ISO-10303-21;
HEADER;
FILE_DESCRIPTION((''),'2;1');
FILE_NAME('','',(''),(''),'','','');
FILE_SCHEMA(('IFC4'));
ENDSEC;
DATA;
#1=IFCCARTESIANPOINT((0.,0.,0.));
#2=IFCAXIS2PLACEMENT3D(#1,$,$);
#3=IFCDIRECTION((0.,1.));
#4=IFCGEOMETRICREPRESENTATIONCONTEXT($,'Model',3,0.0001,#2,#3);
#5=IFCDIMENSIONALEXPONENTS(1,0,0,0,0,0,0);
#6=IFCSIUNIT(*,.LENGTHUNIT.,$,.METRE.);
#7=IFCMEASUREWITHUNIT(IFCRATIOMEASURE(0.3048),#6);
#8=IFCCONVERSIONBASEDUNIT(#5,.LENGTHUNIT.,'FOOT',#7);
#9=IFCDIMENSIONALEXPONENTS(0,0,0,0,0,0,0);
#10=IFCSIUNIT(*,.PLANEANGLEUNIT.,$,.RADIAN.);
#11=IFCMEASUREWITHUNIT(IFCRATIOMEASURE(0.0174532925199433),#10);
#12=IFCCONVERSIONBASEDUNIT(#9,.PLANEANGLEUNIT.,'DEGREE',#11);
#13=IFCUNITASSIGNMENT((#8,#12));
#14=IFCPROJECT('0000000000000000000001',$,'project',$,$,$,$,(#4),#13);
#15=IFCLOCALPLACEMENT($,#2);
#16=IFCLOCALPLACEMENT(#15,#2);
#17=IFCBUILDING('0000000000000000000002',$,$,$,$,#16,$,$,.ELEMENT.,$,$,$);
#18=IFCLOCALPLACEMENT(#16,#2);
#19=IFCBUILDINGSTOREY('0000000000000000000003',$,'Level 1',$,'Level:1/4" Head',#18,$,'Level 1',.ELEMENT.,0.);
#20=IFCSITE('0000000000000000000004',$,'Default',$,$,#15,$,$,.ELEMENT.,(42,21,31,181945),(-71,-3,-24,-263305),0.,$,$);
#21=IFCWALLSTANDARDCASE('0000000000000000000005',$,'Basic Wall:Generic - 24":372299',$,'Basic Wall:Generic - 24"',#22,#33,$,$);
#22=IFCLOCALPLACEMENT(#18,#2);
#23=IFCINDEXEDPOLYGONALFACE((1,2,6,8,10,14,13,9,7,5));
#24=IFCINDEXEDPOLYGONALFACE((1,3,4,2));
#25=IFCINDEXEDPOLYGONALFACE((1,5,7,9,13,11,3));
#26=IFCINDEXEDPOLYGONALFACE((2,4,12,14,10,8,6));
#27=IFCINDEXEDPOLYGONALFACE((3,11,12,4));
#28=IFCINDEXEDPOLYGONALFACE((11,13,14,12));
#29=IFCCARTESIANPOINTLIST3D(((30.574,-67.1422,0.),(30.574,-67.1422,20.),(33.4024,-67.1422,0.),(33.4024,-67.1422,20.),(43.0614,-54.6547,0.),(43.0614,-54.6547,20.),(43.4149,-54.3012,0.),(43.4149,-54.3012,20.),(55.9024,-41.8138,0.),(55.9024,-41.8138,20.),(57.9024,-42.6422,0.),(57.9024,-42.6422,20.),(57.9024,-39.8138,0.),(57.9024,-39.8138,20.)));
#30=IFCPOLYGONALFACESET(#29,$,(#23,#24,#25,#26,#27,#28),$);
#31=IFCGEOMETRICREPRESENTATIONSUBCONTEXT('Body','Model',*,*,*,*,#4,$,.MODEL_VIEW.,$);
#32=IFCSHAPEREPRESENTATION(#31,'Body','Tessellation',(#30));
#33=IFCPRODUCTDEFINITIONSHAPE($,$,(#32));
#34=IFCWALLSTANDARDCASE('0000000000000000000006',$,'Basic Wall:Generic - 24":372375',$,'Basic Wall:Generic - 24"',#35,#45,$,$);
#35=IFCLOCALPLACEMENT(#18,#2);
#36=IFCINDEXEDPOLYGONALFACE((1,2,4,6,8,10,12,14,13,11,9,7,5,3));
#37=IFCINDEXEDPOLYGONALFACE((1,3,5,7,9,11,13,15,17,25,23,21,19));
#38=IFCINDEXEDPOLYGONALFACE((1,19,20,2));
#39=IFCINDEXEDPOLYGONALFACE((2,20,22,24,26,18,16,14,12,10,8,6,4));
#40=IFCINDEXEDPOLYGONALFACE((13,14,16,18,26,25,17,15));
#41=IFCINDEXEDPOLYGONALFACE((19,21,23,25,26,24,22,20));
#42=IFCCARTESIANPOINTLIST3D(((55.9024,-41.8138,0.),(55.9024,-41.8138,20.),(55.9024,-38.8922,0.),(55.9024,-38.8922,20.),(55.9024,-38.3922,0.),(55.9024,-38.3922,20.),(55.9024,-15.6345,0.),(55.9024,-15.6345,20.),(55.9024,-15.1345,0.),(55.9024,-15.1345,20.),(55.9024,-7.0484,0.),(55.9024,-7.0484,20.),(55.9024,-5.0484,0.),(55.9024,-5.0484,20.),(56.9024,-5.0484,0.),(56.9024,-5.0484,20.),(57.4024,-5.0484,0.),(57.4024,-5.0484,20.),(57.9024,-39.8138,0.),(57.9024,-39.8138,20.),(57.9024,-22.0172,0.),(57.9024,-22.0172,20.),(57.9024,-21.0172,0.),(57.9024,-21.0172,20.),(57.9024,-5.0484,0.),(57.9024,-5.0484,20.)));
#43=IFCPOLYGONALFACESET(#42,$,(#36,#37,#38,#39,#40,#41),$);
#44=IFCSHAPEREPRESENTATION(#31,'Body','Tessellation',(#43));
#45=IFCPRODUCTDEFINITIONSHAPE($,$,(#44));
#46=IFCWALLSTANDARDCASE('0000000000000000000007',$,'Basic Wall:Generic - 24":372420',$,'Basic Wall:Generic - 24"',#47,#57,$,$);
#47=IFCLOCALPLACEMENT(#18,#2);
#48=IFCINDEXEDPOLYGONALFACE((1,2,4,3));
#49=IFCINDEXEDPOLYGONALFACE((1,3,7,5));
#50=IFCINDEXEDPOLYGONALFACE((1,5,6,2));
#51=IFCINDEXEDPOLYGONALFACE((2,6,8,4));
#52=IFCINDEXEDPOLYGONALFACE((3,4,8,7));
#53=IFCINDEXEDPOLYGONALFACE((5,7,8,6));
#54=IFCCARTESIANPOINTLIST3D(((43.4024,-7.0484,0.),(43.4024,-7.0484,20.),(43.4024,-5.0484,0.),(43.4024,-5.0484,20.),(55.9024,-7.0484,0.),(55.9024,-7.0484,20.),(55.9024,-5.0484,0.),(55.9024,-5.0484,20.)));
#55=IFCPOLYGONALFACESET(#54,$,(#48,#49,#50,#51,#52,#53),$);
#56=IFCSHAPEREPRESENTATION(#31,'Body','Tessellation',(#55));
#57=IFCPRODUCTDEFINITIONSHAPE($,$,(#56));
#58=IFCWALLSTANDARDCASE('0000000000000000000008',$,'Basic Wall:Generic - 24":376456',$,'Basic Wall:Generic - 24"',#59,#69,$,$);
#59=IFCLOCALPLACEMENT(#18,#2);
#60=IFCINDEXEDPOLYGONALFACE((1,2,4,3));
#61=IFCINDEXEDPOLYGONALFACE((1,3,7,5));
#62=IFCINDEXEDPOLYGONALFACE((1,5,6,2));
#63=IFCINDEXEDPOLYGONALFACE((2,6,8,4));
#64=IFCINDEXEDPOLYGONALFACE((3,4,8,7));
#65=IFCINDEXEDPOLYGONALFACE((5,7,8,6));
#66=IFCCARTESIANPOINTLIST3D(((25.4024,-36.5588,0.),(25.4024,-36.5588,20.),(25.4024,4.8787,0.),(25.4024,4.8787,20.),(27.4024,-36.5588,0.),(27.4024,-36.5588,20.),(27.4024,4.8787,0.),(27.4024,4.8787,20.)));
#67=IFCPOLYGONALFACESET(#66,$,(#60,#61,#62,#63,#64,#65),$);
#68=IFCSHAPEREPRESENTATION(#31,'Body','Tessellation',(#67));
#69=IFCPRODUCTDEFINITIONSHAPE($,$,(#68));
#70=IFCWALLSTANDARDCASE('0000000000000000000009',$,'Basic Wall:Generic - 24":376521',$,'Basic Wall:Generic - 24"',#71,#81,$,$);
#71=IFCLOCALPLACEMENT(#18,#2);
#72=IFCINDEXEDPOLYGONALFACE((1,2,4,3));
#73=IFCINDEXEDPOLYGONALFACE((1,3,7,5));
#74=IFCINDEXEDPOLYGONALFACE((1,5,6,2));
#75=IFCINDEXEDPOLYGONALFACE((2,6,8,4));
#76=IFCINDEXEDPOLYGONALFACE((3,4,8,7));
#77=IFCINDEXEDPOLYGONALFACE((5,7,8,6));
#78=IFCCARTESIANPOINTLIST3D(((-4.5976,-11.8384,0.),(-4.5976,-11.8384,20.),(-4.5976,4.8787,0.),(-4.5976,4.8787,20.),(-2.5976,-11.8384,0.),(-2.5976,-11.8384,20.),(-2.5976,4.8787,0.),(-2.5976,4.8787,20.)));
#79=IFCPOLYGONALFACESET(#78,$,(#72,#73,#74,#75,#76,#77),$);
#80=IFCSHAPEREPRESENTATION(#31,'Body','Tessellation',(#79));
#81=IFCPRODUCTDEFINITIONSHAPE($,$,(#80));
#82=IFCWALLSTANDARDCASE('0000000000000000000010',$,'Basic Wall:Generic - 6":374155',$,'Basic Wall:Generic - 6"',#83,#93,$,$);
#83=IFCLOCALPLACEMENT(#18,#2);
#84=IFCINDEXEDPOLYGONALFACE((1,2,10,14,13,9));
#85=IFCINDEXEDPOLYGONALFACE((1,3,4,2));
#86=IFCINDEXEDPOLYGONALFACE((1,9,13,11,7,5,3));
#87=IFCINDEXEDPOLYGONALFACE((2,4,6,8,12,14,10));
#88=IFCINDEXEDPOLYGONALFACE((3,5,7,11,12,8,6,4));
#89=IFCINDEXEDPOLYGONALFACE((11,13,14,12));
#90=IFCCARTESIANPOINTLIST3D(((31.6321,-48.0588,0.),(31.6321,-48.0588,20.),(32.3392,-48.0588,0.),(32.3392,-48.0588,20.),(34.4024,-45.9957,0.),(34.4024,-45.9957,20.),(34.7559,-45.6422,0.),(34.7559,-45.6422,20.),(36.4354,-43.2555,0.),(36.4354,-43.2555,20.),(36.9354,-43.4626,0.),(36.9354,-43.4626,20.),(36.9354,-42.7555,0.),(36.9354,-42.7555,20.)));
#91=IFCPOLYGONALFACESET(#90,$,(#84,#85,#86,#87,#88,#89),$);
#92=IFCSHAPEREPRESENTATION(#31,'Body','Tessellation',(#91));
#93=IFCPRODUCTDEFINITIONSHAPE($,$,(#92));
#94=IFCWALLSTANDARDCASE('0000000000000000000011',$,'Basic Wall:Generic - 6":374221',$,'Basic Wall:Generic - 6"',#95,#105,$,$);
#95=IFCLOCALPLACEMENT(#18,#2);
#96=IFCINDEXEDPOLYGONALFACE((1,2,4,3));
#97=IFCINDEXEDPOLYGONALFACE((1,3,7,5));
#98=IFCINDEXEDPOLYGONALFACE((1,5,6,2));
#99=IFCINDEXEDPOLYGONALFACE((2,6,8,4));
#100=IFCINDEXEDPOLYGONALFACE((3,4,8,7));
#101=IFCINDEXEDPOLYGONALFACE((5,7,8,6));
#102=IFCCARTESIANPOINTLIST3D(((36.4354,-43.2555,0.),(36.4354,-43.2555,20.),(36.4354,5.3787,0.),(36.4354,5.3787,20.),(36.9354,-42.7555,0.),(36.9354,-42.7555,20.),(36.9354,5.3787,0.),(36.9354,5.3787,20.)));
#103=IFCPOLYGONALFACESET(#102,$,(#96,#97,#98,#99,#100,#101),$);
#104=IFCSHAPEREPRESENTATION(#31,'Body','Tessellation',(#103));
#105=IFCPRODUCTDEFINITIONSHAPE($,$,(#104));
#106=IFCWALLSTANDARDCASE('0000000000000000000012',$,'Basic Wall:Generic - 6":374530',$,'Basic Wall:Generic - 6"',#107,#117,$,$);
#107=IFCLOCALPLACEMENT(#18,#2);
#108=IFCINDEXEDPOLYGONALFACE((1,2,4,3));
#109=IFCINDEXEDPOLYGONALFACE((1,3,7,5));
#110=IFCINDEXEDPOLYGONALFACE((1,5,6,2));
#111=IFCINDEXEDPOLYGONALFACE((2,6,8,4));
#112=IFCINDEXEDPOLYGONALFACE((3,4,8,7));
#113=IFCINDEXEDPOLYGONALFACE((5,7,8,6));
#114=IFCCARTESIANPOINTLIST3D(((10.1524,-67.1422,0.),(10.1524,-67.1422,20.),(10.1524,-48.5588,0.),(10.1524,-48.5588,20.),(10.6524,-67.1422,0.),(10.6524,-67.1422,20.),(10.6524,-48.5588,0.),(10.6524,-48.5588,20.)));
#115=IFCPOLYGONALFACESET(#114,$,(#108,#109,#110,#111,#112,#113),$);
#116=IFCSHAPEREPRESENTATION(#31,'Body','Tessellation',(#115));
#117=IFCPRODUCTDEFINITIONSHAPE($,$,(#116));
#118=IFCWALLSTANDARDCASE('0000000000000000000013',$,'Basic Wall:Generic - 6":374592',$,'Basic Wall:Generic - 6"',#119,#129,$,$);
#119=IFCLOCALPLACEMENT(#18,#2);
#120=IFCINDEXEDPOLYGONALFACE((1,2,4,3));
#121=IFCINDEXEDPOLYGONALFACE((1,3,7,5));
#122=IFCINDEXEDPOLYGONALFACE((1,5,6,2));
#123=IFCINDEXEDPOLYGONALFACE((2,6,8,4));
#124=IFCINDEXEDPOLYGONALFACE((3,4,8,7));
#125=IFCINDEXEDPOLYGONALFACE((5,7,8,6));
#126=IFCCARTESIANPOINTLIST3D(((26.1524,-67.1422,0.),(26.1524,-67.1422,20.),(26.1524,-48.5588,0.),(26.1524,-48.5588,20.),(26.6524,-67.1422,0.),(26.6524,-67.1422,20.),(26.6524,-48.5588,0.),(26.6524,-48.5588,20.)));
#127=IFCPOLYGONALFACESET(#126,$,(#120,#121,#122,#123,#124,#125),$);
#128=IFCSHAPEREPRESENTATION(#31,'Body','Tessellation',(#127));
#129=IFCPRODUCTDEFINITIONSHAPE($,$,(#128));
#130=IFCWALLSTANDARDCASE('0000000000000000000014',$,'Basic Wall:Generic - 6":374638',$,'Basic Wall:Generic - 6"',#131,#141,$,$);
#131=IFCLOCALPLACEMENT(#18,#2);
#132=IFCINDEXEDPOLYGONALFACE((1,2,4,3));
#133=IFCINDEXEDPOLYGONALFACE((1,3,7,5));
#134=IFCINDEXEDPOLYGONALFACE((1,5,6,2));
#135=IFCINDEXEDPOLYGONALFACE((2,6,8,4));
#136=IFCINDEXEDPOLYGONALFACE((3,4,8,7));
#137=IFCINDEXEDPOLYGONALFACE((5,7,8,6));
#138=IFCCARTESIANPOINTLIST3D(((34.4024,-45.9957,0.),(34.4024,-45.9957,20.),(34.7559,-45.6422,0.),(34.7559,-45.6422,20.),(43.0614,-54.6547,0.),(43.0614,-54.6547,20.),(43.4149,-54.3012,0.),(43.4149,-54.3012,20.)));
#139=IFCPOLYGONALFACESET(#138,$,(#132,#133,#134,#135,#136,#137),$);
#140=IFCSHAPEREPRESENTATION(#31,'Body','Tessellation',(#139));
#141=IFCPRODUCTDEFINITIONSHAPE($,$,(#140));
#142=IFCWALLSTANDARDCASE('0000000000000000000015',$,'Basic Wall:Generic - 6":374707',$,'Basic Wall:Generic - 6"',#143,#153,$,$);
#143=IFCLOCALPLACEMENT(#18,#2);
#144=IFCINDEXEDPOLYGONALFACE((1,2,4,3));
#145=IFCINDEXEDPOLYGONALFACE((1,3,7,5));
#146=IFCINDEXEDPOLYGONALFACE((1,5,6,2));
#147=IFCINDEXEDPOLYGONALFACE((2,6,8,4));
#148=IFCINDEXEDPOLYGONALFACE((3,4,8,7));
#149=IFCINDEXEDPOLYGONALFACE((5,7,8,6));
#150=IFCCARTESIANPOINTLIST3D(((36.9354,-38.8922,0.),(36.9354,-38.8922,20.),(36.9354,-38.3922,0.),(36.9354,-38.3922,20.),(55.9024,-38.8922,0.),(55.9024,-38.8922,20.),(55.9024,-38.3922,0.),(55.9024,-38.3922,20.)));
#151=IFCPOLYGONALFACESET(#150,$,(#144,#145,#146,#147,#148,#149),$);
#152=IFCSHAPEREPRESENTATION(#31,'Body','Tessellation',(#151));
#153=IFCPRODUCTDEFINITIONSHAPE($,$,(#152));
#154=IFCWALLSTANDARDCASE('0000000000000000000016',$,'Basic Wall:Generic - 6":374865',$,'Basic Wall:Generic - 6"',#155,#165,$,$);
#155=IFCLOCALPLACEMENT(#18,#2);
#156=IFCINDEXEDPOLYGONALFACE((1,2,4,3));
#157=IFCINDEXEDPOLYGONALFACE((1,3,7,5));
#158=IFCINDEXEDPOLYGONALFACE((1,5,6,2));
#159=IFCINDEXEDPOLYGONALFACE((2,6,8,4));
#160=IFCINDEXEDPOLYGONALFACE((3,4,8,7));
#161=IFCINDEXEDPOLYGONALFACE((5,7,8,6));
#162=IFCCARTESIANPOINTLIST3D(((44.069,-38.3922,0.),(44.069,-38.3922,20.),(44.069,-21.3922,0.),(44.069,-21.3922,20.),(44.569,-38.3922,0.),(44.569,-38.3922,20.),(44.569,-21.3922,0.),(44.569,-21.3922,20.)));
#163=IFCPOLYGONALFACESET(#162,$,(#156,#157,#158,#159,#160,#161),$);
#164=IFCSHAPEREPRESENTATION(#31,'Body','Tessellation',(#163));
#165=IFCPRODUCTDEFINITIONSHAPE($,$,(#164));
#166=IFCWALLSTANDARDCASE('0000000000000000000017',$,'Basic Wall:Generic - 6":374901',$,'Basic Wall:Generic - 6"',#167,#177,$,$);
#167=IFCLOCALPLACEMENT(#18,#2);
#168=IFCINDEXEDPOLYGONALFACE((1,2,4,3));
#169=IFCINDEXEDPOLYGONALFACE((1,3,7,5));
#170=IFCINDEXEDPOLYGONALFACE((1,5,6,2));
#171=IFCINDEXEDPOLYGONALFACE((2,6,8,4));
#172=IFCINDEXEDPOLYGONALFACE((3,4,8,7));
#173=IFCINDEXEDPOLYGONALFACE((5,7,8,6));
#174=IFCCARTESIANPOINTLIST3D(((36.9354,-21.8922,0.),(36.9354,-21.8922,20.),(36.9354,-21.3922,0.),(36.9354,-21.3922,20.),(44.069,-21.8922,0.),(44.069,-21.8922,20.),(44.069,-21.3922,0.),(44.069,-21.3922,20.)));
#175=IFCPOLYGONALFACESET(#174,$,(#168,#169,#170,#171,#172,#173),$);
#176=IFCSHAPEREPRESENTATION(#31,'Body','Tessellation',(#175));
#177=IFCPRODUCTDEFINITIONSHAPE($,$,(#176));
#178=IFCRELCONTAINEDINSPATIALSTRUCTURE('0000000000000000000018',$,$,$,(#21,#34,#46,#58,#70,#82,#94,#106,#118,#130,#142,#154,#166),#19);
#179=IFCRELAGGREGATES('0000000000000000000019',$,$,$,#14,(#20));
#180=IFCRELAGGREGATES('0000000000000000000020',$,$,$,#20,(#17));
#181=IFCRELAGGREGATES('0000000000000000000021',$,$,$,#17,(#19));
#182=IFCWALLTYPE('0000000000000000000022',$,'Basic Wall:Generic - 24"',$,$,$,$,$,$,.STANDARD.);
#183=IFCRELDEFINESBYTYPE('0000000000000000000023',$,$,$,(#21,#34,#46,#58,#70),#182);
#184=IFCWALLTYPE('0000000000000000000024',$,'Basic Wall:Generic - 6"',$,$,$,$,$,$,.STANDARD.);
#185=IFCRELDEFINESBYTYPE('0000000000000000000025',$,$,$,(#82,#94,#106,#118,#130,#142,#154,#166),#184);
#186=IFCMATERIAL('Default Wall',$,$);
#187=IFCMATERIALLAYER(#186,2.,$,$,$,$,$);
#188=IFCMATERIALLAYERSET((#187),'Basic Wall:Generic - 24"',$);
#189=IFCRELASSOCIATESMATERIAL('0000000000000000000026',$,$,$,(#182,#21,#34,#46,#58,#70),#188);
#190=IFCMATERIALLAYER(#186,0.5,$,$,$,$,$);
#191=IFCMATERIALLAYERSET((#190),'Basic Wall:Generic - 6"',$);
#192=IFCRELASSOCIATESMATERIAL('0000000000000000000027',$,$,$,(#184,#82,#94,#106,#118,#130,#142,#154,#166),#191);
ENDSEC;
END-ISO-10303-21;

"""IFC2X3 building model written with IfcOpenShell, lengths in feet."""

from ifc_helpers import new_model, entity, si_unit, converted_unit, direction, frame, frame_2d, origin, place, context, subcontext, project, spatial, polyline, rectangle, outline, extrude, material, layer, layer_set, layer_usage, type_object, element, save


model = new_model("IFC2X3")

# Units and contexts
model_context = context("Model", 3, precision=0.0001, world=origin(), true_north=direction((0.0, 1.0)))
body_context = subcontext(model_context, "Body", "Model", "MODEL_VIEW")
ifc_project = project(units=[converted_unit("LENGTHUNIT", "FOOT", entity("IfcRatioMeasure", 0.3048), si_unit("LENGTHUNIT", "METRE"), dimensions=[1, 0, 0, 0, 0, 0, 0]), converted_unit("PLANEANGLEUNIT", "DEGREE", entity("IfcRatioMeasure", 0.0174532925199433), si_unit("PLANEANGLEUNIT", "RADIAN"), dimensions=[0, 0, 0, 0, 0, 0, 0])], contexts=[model_context])

# Site, building, storey
site_placement = place(None, origin())
site = spatial("IfcSite", under=ifc_project, at=site_placement, Name="Default", CompositionType="ELEMENT", RefLatitude=(42, 21, 31, 181945), RefLongitude=(-71, -3, -24, -263305), RefElevation=0.0)
building_placement = place(site_placement, origin())
building = spatial("IfcBuilding", under=site, at=building_placement, CompositionType="ELEMENT")
storey_placement = place(building_placement, origin())
storey = spatial("IfcBuildingStorey", under=building, at=storey_placement, Name="Level 1", ObjectType="Level:1/4\" Head", LongName="Level 1", CompositionType="ELEMENT", Elevation=0.0)

# Walls
ifc_material = material(Name="Default Wall")
ifc_layer_1 = layer(ifc_material, 2.0)
ifc_layer_set_1 = layer_set([ifc_layer_1], Name="Basic Wall:Generic - 24\"")
ifc_layer_usage_1 = layer_usage(ifc_layer_set_1, "AXIS2", "NEGATIVE", 1.0)
wall_type_1 = type_object("IfcWallType", Name="Basic Wall:Generic - 24\"", PredefinedType="STANDARD", material=ifc_layer_set_1)
wall_1_placement = place(storey_placement, frame((31.2811, -67.8493, 0.0), z_axis=(0.0, 0.0, 1.0), x_axis=(0.707107, 0.707107, 0.0)))
element("IfcWallStandardCase", 1, at=wall_1_placement, inside=storey, type_object=wall_type_1, material=ifc_layer_usage_1, Name="Basic Wall:Generic - 24\":372299", ObjectType="Basic Wall:Generic - 24\"", context=body_context, shape_type="SweptSolid", body=[
    extrude(outline(polyline([(36.6482, -1.0), (38.6482, 1.0), (35.8198, 1.0), (18.1599, 1.0), (17.6599, 1.0), (0.0, 1.0), (2.0, -1.0), (36.6482, -1.0)])), origin(), (0.0, 0.0, 1.0), 20.0),
])
ifc_layer_usage_2 = layer_usage(ifc_layer_set_1, "AXIS2", "NEGATIVE", 1.0)
wall_2_placement = place(storey_placement, frame((56.9024, -41.8138, 0.0), z_axis=(0.0, 0.0, 1.0), x_axis=(0.0, 1.0, 0.0)))
element("IfcWallStandardCase", 2, at=wall_2_placement, inside=storey, type_object=wall_type_1, material=ifc_layer_usage_2, Name="Basic Wall:Generic - 24\":372375", ObjectType="Basic Wall:Generic - 24\"", context=body_context, shape_type="SweptSolid", body=[
    extrude(outline(polyline([(36.7654, -1.0), (36.7654, -0.5), (36.7654, 0.0), (36.7654, 1.0), (34.7654, 1.0), (26.6793, 1.0), (26.1793, 1.0), (3.4216, 1.0), (2.9216, 1.0), (0.0, 1.0), (2.0, -1.0), (19.7966, -1.0), (20.7966, -1.0), (36.7654, -1.0)])), origin(), (0.0, 0.0, 1.0), 20.0),
])
ifc_layer_usage_3 = layer_usage(ifc_layer_set_1, "AXIS2", "NEGATIVE", 1.0)
wall_3_placement = place(storey_placement, frame((55.9024, -6.0484, 0.0), z_axis=(0.0, 0.0, 1.0), x_axis=(-1.0, 0.0, 0.0)))
element("IfcWallStandardCase", 3, at=wall_3_placement, inside=storey, type_object=wall_type_1, material=ifc_layer_usage_3, Name="Basic Wall:Generic - 24\":372420", ObjectType="Basic Wall:Generic - 24\"", context=body_context, shape_type="SweptSolid", body=[
    extrude(rectangle(XDim=12.5, YDim=2.0, at=frame_2d((6.25, 0.0), x_axis=(-1.0, 0.0))), origin(), (0.0, 0.0, 1.0), 20.0),
])
ifc_layer_usage_4 = layer_usage(ifc_layer_set_1, "AXIS2", "NEGATIVE", 1.0)
wall_4_placement = place(storey_placement, frame((26.4024, 4.8787, 0.0), z_axis=(0.0, 0.0, 1.0), x_axis=(0.0, -1.0, 0.0)))
element("IfcWallStandardCase", 4, at=wall_4_placement, inside=storey, type_object=wall_type_1, material=ifc_layer_usage_4, Name="Basic Wall:Generic - 24\":376456", ObjectType="Basic Wall:Generic - 24\"", context=body_context, shape_type="SweptSolid", body=[
    extrude(rectangle(XDim=41.4375, YDim=2.0, at=frame_2d((20.7188, 0.0), x_axis=(-1.0, 0.0))), origin(), (0.0, 0.0, 1.0), 20.0),
])
ifc_layer_usage_5 = layer_usage(ifc_layer_set_1, "AXIS2", "NEGATIVE", 1.0)
wall_5_placement = place(storey_placement, frame((-3.5976, 4.8787, 0.0), z_axis=(0.0, 0.0, 1.0), x_axis=(0.0, -1.0, 0.0)))
element("IfcWallStandardCase", 5, at=wall_5_placement, inside=storey, type_object=wall_type_1, material=ifc_layer_usage_5, Name="Basic Wall:Generic - 24\":376521", ObjectType="Basic Wall:Generic - 24\"", context=body_context, shape_type="SweptSolid", body=[
    extrude(rectangle(XDim=16.7171, YDim=2.0, at=frame_2d((8.3585, 0.0), x_axis=(-1.0, 0.0))), origin(), (0.0, 0.0, 1.0), 20.0),
])
ifc_layer_2 = layer(ifc_material, 0.5)
ifc_layer_set_2 = layer_set([ifc_layer_2], Name="Basic Wall:Generic - 6\"")
ifc_layer_usage_6 = layer_usage(ifc_layer_set_2, "AXIS2", "NEGATIVE", 0.25)
wall_type_2 = type_object("IfcWallType", Name="Basic Wall:Generic - 6\"", PredefinedType="STANDARD", material=ifc_layer_set_2)
wall_6_placement = place(storey_placement, frame((31.8089, -48.2356, 0.0), z_axis=(0.0, 0.0, 1.0), x_axis=(0.707107, 0.707107, 0.0)))
element("IfcWallStandardCase", 6, at=wall_6_placement, inside=storey, type_object=wall_type_2, material=ifc_layer_usage_6, Name="Basic Wall:Generic - 6\":374155", ObjectType="Basic Wall:Generic - 6\"", context=body_context, shape_type="SweptSolid", body=[
    extrude(outline(polyline([(7.0, -0.25), (7.5, 0.25), (6.7929, 0.25), (0.0, 0.25), (0.5, -0.25), (3.4177, -0.25), (3.9177, -0.25), (7.0, -0.25)])), origin(), (0.0, 0.0, 1.0), 20.0),
])
ifc_layer_usage_7 = layer_usage(ifc_layer_set_2, "AXIS2", "NEGATIVE", 0.25)
wall_7_placement = place(storey_placement, frame((36.6854, -43.2555, 0.0), z_axis=(0.0, 0.0, 1.0), x_axis=(0.0, 1.0, 0.0)))
element("IfcWallStandardCase", 7, at=wall_7_placement, inside=storey, type_object=wall_type_2, material=ifc_layer_usage_7, Name="Basic Wall:Generic - 6\":374221", ObjectType="Basic Wall:Generic - 6\"", context=body_context, shape_type="SweptSolid", body=[
    extrude(outline(polyline([(48.6342, -0.25), (48.6342, 0.25), (0.0, 0.25), (0.5, -0.25), (48.6342, -0.25)])), origin(), (0.0, 0.0, 1.0), 20.0),
])
ifc_layer_usage_8 = layer_usage(ifc_layer_set_2, "AXIS2", "NEGATIVE", 0.25)
wall_8_placement = place(storey_placement, frame((10.4024, -67.1422, 0.0), z_axis=(0.0, 0.0, 1.0), x_axis=(0.0, 1.0, 0.0)))
element("IfcWallStandardCase", 8, at=wall_8_placement, inside=storey, type_object=wall_type_2, material=ifc_layer_usage_8, Name="Basic Wall:Generic - 6\":374530", ObjectType="Basic Wall:Generic - 6\"", context=body_context, shape_type="SweptSolid", body=[
    extrude(rectangle(XDim=18.5833, YDim=0.5, at=frame_2d((9.2917, 0.0), x_axis=(-1.0, 0.0))), origin(), (0.0, 0.0, 1.0), 20.0),
])
ifc_layer_usage_9 = layer_usage(ifc_layer_set_2, "AXIS2", "NEGATIVE", 0.25)
wall_9_placement = place(storey_placement, frame((26.4024, -67.1422, 0.0), z_axis=(0.0, 0.0, 1.0), x_axis=(0.0, 1.0, 0.0)))
element("IfcWallStandardCase", 9, at=wall_9_placement, inside=storey, type_object=wall_type_2, material=ifc_layer_usage_9, Name="Basic Wall:Generic - 6\":374592", ObjectType="Basic Wall:Generic - 6\"", context=body_context, shape_type="SweptSolid", body=[
    extrude(rectangle(XDim=18.5833, YDim=0.5, at=frame_2d((9.2917, 0.0), x_axis=(-1.0, 0.0))), origin(), (0.0, 0.0, 1.0), 20.0),
])
ifc_layer_usage_10 = layer_usage(ifc_layer_set_2, "AXIS2", "NEGATIVE", 0.25)
wall_10_placement = place(storey_placement, frame((43.2382, -54.478, 0.0), z_axis=(0.0, 0.0, 1.0), x_axis=(-0.707107, 0.707107, 0.0)))
element("IfcWallStandardCase", 10, at=wall_10_placement, inside=storey, type_object=wall_type_2, material=ifc_layer_usage_10, Name="Basic Wall:Generic - 6\":374638", ObjectType="Basic Wall:Generic - 6\"", context=body_context, shape_type="SweptSolid", body=[
    extrude(rectangle(XDim=12.2457, YDim=0.5, at=frame_2d((6.1229, 0.0), x_axis=(-1.0, 0.0))), origin(), (0.0, 0.0, 1.0), 20.0),
])
ifc_layer_usage_11 = layer_usage(ifc_layer_set_2, "AXIS2", "NEGATIVE", 0.25)
wall_11_placement = place(storey_placement, frame((55.9024, -38.6422, 0.0), z_axis=(0.0, 0.0, 1.0), x_axis=(-1.0, 0.0, 0.0)))
element("IfcWallStandardCase", 11, at=wall_11_placement, inside=storey, type_object=wall_type_2, material=ifc_layer_usage_11, Name="Basic Wall:Generic - 6\":374707", ObjectType="Basic Wall:Generic - 6\"", context=body_context, shape_type="SweptSolid", body=[
    extrude(rectangle(XDim=18.9669, YDim=0.5, at=frame_2d((9.4835, 0.0), x_axis=(-1.0, 0.0))), origin(), (0.0, 0.0, 1.0), 20.0),
])
ifc_layer_usage_12 = layer_usage(ifc_layer_set_2, "AXIS2", "NEGATIVE", 0.25)
wall_12_placement = place(storey_placement, frame((44.319, -38.3922, 0.0), z_axis=(0.0, 0.0, 1.0), x_axis=(0.0, 1.0, 0.0)))
element("IfcWallStandardCase", 12, at=wall_12_placement, inside=storey, type_object=wall_type_2, material=ifc_layer_usage_12, Name="Basic Wall:Generic - 6\":374865", ObjectType="Basic Wall:Generic - 6\"", context=body_context, shape_type="SweptSolid", body=[
    extrude(rectangle(XDim=17.0, YDim=0.5, at=frame_2d((8.5, 0.0), x_axis=(-1.0, 0.0))), origin(), (0.0, 0.0, 1.0), 20.0),
])
ifc_layer_usage_13 = layer_usage(ifc_layer_set_2, "AXIS2", "NEGATIVE", 0.25)
wall_13_placement = place(storey_placement, frame((44.069, -21.6422, 0.0), z_axis=(0.0, 0.0, 1.0), x_axis=(-1.0, 0.0, 0.0)))
element("IfcWallStandardCase", 13, at=wall_13_placement, inside=storey, type_object=wall_type_2, material=ifc_layer_usage_13, Name="Basic Wall:Generic - 6\":374901", ObjectType="Basic Wall:Generic - 6\"", context=body_context, shape_type="SweptSolid", body=[
    extrude(rectangle(XDim=7.1336, YDim=0.5, at=frame_2d((3.5668, 0.0), x_axis=(-1.0, 0.0))), origin(), (0.0, 0.0, 1.0), 20.0),
])

save(model, "model.ifc")
